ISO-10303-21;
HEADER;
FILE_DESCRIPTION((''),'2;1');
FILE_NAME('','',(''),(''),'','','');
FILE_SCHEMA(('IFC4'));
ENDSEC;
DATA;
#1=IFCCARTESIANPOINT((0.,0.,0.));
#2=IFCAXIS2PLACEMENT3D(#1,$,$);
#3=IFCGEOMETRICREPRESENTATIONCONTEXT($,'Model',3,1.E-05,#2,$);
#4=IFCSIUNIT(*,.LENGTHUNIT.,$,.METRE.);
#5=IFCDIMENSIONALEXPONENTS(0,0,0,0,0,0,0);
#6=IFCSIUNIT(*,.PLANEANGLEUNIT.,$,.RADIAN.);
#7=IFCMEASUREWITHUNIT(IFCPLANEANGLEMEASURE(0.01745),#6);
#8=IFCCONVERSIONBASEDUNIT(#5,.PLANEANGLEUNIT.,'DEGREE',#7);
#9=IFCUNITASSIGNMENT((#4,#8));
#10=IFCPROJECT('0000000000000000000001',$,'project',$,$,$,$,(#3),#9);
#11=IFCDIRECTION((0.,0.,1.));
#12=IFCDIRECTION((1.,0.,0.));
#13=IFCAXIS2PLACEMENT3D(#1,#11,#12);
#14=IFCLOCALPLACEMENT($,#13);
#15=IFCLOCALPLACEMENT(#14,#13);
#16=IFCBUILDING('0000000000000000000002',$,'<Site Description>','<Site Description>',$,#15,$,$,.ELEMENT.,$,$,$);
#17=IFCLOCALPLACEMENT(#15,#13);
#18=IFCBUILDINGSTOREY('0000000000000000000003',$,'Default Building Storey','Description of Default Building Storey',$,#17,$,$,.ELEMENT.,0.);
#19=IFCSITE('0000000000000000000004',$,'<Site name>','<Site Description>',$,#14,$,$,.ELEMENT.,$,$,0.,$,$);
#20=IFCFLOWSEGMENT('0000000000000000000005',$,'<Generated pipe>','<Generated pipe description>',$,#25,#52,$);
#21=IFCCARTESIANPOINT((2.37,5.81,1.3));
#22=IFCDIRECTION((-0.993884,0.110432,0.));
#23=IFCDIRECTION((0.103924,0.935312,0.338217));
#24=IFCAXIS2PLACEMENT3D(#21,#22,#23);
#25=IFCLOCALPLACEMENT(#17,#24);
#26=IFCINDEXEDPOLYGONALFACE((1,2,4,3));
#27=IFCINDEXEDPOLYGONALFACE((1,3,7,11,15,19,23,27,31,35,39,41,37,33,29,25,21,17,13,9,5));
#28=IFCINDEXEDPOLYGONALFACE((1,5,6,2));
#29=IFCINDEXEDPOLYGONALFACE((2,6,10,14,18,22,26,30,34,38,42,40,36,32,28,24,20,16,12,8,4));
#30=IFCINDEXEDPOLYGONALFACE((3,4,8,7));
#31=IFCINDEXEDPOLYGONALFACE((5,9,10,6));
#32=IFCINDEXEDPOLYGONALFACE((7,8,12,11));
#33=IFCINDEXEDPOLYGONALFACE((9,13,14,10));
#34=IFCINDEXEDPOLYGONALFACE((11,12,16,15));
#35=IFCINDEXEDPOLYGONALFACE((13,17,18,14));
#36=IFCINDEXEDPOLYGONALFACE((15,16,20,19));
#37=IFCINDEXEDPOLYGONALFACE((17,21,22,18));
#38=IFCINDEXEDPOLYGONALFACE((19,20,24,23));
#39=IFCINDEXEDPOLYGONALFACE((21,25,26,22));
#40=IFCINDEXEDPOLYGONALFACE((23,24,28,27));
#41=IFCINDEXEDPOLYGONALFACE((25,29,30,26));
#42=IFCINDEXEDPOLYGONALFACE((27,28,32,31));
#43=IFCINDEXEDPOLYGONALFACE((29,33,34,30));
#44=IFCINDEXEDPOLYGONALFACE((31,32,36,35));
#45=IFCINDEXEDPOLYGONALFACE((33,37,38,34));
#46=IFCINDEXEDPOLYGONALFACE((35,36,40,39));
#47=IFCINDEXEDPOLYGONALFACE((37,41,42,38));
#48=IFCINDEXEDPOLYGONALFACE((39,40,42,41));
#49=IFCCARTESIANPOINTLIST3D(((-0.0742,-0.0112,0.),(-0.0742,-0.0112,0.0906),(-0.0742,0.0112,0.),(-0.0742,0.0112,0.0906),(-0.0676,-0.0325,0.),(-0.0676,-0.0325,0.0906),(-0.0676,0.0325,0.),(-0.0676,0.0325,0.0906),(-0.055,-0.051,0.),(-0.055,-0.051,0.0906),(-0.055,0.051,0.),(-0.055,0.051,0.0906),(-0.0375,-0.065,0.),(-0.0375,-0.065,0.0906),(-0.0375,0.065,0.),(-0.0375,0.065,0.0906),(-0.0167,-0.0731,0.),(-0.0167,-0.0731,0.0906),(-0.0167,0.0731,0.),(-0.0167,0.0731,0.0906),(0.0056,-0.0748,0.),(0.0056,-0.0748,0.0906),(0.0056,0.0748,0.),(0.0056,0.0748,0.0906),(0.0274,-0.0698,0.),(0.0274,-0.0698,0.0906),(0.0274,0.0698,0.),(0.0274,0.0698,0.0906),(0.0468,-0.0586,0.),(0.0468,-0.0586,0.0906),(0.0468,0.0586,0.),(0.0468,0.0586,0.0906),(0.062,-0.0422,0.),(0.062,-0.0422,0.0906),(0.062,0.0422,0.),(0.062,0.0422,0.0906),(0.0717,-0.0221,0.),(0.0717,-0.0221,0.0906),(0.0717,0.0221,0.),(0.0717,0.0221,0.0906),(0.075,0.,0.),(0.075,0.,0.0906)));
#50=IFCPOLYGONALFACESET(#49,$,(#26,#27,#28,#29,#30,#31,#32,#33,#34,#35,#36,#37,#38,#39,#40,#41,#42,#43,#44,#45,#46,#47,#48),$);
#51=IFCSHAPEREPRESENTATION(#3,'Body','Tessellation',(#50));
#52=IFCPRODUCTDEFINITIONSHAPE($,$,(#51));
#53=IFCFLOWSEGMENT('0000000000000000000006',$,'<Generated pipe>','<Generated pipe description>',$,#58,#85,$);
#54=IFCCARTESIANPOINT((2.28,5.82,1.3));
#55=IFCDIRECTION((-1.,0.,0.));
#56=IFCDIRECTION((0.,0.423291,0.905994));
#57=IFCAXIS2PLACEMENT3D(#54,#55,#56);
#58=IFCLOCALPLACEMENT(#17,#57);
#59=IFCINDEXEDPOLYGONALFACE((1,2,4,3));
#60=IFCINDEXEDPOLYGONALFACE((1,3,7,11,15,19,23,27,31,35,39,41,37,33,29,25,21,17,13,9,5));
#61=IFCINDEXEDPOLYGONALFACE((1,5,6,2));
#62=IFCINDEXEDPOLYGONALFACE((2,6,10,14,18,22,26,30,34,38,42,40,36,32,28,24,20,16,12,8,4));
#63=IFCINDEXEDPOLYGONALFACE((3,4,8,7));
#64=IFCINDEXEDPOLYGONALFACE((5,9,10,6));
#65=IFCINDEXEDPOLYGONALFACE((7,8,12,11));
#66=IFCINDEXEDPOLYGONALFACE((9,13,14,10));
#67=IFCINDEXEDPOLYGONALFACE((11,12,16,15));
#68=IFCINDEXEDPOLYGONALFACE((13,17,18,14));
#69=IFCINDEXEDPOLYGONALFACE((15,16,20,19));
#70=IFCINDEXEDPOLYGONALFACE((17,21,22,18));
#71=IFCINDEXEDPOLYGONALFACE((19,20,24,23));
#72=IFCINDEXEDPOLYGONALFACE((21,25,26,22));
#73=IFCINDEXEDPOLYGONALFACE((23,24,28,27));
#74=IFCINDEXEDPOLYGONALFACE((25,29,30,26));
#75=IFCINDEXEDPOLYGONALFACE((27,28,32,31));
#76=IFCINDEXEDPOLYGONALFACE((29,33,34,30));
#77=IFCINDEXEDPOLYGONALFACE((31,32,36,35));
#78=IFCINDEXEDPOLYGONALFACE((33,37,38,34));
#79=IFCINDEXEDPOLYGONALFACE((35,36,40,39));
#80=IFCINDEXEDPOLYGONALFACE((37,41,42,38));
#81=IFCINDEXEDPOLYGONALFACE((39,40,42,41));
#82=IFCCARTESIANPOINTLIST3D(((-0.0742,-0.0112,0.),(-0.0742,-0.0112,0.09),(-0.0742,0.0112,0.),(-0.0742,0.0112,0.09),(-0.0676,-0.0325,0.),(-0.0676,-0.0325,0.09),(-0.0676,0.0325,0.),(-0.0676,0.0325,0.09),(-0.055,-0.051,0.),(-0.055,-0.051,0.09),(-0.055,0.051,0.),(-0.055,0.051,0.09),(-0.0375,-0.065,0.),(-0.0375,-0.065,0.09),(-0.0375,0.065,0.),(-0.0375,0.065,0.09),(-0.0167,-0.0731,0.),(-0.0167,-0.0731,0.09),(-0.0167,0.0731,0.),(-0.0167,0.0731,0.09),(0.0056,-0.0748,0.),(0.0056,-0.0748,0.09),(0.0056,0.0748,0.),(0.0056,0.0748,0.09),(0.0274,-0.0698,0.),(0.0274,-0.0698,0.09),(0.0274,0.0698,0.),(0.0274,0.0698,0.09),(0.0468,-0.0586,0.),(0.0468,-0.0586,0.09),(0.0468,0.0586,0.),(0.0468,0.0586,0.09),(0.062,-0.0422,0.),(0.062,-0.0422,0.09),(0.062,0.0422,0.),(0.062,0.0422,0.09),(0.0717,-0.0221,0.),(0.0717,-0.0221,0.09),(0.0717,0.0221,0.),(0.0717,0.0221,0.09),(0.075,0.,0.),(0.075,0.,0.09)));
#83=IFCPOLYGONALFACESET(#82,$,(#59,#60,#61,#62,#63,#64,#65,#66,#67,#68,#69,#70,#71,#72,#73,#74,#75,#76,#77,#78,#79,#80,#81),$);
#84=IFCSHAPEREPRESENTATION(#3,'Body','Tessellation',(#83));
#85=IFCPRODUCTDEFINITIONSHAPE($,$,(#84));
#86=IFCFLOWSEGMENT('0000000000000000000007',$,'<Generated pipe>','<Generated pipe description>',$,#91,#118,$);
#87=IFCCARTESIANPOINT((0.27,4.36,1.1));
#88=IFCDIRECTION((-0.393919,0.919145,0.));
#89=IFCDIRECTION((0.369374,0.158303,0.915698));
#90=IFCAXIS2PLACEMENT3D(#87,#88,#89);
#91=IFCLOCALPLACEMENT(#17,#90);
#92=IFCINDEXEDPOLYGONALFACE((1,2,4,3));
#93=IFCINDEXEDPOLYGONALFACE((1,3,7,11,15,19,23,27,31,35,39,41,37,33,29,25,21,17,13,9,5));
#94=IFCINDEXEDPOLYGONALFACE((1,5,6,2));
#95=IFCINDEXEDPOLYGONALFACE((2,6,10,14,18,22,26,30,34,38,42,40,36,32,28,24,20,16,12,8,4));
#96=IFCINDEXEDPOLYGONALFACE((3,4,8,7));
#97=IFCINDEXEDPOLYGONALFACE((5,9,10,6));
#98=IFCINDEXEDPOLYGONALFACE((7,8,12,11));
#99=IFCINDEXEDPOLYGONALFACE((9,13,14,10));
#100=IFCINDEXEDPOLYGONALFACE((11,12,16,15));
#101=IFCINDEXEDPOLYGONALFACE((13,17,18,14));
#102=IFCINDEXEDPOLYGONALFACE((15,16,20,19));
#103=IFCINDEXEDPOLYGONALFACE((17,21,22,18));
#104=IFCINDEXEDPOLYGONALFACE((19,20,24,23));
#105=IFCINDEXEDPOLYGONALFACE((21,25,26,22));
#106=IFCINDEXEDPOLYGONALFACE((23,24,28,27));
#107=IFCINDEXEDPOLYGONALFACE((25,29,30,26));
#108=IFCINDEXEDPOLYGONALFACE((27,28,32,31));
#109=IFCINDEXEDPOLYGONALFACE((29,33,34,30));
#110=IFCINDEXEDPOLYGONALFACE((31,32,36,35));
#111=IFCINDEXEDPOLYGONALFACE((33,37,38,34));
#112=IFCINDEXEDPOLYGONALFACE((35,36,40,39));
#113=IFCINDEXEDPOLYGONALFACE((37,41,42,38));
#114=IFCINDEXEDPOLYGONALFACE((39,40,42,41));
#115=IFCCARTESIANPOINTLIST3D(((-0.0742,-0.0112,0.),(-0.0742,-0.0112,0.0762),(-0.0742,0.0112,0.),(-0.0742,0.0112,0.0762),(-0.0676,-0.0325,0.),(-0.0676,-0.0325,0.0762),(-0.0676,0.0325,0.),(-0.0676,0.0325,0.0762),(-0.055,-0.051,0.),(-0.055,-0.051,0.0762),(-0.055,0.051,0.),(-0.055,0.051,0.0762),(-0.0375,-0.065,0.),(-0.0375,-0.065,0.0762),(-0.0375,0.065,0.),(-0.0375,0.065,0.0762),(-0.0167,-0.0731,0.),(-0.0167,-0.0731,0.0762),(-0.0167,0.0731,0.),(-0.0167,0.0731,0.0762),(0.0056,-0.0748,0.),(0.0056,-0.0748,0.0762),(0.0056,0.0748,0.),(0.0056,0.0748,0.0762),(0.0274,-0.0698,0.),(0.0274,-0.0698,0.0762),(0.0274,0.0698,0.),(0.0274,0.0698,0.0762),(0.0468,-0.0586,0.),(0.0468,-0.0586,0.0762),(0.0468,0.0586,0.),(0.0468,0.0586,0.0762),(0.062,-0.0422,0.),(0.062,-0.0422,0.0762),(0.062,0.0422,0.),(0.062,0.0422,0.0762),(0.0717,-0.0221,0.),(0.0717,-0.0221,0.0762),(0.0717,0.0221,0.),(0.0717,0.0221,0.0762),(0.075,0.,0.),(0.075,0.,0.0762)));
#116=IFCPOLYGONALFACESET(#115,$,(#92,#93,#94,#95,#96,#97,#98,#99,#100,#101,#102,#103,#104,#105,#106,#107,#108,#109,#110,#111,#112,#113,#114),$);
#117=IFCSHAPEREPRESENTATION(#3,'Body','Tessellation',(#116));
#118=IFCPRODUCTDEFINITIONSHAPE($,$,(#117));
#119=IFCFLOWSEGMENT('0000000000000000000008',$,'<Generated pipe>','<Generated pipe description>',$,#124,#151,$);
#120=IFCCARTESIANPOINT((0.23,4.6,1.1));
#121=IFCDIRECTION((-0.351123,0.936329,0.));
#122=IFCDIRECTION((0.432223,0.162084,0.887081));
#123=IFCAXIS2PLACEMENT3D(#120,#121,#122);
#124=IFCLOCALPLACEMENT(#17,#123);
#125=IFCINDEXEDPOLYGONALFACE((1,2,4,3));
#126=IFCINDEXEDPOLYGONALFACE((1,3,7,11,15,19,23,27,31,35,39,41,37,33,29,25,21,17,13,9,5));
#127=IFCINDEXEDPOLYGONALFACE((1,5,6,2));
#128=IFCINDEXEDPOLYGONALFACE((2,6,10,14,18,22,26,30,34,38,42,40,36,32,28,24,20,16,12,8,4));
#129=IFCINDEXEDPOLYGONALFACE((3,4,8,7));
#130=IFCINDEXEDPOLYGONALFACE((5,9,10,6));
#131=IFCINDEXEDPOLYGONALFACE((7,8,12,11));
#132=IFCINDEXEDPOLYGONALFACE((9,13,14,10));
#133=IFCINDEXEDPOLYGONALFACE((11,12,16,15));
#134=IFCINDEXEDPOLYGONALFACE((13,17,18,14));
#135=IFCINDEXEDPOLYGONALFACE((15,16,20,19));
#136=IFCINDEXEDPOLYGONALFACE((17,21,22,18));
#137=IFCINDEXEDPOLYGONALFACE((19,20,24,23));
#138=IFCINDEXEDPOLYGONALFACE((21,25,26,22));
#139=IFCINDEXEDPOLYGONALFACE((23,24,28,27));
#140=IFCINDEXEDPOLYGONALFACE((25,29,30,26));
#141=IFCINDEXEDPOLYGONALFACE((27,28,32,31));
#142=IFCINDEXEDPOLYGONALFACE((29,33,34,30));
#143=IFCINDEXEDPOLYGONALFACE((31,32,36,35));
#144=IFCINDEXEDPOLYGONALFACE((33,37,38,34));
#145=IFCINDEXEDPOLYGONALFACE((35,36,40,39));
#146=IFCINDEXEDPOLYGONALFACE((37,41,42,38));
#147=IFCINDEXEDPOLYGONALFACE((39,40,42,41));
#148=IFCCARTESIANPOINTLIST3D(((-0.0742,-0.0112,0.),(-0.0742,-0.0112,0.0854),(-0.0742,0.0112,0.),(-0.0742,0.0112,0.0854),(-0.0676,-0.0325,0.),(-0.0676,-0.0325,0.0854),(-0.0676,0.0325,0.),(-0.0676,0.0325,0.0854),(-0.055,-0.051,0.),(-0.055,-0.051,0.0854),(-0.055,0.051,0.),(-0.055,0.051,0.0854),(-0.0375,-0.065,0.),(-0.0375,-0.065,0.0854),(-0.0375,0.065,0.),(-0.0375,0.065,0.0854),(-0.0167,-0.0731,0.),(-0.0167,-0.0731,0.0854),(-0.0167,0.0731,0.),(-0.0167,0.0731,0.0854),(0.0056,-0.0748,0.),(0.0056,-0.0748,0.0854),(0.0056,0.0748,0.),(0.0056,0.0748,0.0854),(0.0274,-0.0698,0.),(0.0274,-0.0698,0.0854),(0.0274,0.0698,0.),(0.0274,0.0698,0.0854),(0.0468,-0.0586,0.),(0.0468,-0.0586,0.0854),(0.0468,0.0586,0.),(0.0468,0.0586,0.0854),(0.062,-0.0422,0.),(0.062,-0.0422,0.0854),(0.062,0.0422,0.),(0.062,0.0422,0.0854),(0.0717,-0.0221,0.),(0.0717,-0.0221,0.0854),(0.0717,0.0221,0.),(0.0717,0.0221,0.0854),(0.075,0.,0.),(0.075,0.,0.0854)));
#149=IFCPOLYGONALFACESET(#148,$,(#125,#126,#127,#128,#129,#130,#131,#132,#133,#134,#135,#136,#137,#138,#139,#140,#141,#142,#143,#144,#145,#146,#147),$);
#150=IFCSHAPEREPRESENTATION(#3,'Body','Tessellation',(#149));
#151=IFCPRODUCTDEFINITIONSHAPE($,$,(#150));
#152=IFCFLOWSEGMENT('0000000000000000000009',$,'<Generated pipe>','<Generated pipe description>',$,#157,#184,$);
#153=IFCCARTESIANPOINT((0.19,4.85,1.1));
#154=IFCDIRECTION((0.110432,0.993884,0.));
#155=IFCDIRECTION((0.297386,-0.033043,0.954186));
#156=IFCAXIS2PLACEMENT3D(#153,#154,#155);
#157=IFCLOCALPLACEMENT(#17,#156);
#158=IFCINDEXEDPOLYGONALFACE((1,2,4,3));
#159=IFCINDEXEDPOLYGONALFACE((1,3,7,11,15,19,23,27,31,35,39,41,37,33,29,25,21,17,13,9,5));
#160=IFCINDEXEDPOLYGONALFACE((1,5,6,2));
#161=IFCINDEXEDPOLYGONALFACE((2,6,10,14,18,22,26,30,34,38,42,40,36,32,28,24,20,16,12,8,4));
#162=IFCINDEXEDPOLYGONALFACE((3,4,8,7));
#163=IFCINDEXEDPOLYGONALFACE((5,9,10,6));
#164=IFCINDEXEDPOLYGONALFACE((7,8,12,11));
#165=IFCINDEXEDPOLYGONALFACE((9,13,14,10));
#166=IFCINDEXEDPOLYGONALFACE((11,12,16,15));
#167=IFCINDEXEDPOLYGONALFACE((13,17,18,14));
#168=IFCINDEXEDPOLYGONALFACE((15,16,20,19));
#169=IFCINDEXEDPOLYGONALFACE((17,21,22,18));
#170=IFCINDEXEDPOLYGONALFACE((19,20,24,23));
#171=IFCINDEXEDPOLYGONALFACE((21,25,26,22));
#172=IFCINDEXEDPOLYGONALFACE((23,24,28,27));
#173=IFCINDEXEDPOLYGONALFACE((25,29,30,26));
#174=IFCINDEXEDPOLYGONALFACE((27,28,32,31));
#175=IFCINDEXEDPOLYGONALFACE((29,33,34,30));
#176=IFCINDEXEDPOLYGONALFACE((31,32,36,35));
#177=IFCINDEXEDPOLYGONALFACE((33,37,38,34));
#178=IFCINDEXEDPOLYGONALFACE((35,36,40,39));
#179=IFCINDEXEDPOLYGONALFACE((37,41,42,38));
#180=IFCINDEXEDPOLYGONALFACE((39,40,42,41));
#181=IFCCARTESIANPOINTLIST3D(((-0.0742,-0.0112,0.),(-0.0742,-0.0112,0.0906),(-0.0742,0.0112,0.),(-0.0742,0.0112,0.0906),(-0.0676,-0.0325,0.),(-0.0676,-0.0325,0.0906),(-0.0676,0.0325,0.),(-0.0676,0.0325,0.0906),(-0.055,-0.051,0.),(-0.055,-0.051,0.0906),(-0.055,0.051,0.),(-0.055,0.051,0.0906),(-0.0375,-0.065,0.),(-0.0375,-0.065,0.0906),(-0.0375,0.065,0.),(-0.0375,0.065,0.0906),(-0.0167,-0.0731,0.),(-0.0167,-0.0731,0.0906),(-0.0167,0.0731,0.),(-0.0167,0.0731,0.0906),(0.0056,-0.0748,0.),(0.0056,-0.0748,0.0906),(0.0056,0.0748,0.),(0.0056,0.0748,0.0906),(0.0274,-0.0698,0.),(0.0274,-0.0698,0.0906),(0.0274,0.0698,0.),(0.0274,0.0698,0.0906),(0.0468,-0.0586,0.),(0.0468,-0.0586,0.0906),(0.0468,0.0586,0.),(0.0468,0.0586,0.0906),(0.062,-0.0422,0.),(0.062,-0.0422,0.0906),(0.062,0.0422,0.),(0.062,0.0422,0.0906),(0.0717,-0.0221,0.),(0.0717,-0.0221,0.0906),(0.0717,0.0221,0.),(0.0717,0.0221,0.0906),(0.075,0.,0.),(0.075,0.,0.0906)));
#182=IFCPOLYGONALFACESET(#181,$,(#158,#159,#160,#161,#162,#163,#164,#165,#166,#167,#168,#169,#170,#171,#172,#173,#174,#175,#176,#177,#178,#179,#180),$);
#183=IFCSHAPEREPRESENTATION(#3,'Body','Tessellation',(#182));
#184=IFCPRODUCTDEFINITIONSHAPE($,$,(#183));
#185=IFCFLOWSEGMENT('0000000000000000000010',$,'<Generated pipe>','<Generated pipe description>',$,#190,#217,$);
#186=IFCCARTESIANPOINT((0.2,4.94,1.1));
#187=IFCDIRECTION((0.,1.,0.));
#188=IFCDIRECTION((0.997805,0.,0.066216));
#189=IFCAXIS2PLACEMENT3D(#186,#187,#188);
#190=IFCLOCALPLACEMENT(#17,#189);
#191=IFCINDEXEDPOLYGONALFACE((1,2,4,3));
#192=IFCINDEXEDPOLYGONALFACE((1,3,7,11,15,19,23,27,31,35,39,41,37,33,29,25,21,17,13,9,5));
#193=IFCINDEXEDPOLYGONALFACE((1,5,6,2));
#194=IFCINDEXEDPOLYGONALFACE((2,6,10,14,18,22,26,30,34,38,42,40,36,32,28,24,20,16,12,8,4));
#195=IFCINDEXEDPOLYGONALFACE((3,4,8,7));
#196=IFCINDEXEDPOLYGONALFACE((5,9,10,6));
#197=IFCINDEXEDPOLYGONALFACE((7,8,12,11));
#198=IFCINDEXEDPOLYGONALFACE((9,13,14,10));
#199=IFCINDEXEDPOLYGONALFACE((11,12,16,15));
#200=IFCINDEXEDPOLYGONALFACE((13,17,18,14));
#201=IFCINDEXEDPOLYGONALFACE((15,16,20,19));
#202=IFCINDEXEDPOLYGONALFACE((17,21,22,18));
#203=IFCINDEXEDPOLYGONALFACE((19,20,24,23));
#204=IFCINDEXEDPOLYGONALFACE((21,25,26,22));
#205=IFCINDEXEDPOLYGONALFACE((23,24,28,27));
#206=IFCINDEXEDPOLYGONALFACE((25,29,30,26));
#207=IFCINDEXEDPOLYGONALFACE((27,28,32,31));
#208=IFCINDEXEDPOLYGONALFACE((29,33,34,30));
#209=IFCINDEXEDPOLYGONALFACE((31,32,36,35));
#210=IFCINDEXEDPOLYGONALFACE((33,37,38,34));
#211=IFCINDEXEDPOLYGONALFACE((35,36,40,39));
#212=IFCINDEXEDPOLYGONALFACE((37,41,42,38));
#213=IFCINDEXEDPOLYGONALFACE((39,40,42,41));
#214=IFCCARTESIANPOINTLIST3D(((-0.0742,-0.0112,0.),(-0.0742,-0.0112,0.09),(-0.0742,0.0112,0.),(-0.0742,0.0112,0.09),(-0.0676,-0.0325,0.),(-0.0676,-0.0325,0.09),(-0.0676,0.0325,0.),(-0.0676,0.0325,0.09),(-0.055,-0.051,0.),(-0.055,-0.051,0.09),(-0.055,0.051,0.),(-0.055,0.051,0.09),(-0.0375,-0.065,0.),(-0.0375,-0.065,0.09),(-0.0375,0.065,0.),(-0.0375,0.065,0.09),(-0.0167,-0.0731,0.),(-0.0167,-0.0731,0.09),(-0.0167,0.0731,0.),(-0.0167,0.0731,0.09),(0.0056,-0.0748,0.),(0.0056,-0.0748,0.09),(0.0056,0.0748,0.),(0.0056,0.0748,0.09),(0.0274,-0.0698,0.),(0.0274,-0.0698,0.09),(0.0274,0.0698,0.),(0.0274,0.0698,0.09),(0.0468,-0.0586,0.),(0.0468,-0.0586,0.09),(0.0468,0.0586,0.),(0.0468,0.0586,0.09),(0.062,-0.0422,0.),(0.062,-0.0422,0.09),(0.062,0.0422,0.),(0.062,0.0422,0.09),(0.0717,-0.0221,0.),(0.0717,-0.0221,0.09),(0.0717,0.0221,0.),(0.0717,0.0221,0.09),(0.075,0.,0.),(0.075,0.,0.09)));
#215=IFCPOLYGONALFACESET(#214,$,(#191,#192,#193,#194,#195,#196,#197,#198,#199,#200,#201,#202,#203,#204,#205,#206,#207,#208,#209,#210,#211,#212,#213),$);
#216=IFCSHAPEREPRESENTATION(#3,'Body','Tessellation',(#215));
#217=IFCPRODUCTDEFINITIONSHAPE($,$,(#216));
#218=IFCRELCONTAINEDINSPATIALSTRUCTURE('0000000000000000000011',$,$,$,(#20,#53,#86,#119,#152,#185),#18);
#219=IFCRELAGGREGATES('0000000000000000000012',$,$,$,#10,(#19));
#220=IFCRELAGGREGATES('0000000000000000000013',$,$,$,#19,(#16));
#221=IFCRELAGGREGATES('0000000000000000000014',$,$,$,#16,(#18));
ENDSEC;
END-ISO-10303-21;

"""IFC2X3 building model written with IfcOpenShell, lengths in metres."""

from ifc_helpers import new_model, entity, si_unit, converted_unit, frame, origin, origin_with_axes, origin_2d_with_axis, place, context, project, spatial, circle, extrude, element, save


model = new_model("IFC2X3")

# Units and contexts
model_context = context("Model", 3, precision=1e-05, world=origin())
ifc_project = project(units=[si_unit("LENGTHUNIT", "METRE"), converted_unit("PLANEANGLEUNIT", "DEGREE", entity("IfcPlaneAngleMeasure", 0.01745), si_unit("PLANEANGLEUNIT", "RADIAN"), dimensions=[0, 0, 0, 0, 0, 0, 0])], contexts=[model_context])

# Site, building, storey
site_placement = place(None, origin_with_axes())
site = spatial("IfcSite", under=ifc_project, at=site_placement, Name="<Site name>", Description="<Site Description>", CompositionType="ELEMENT", RefElevation=0.0)
building_placement = place(site_placement, origin_with_axes())
building = spatial("IfcBuilding", under=site, at=building_placement, Name="<Site Description>", Description="<Site Description>", CompositionType="ELEMENT")
storey_placement = place(building_placement, origin_with_axes())
storey = spatial("IfcBuildingStorey", under=building, at=storey_placement, Name="Default Building Storey", Description="Description of Default Building Storey", CompositionType="ELEMENT", Elevation=0.0)

# Flow segments
flow_segment_1_placement = place(storey_placement, frame((2.37, 5.81, 1.3), z_axis=(-0.993884, 0.110432, 0.0), x_axis=(0.103924, 0.935312, 0.338217)))
element("IfcFlowSegment", 1, at=flow_segment_1_placement, inside=storey, Name="<Generated pipe>", Description="<Generated pipe description>", context=model_context, shape_type="SweptSolid", body=[
    extrude(circle(Radius=0.075, at=origin_2d_with_axis()), origin_with_axes(), (0.0, 0.0, 1.0), 0.0906),
])
flow_segment_2_placement = place(storey_placement, frame((2.28, 5.82, 1.3), z_axis=(-1.0, 0.0, 0.0), x_axis=(0.0, 0.423291, 0.905994)))
element("IfcFlowSegment", 2, at=flow_segment_2_placement, inside=storey, Name="<Generated pipe>", Description="<Generated pipe description>", context=model_context, shape_type="SweptSolid", body=[
    extrude(circle(Radius=0.075, at=origin_2d_with_axis()), origin_with_axes(), (0.0, 0.0, 1.0), 0.09),
])
flow_segment_3_placement = place(storey_placement, frame((0.27, 4.36, 1.1), z_axis=(-0.393919, 0.919145, 0.0), x_axis=(0.369374, 0.158303, 0.915698)))
element("IfcFlowSegment", 3, at=flow_segment_3_placement, inside=storey, Name="<Generated pipe>", Description="<Generated pipe description>", context=model_context, shape_type="SweptSolid", body=[
    extrude(circle(Radius=0.075, at=origin_2d_with_axis()), origin_with_axes(), (0.0, 0.0, 1.0), 0.0762),
])
flow_segment_4_placement = place(storey_placement, frame((0.23, 4.6, 1.1), z_axis=(-0.351123, 0.936329, 0.0), x_axis=(0.432223, 0.162084, 0.887081)))
element("IfcFlowSegment", 4, at=flow_segment_4_placement, inside=storey, Name="<Generated pipe>", Description="<Generated pipe description>", context=model_context, shape_type="SweptSolid", body=[
    extrude(circle(Radius=0.075, at=origin_2d_with_axis()), origin_with_axes(), (0.0, 0.0, 1.0), 0.0854),
])
flow_segment_5_placement = place(storey_placement, frame((0.19, 4.85, 1.1), z_axis=(0.110432, 0.993884, 0.0), x_axis=(0.297386, -0.033043, 0.954186)))
element("IfcFlowSegment", 5, at=flow_segment_5_placement, inside=storey, Name="<Generated pipe>", Description="<Generated pipe description>", context=model_context, shape_type="SweptSolid", body=[
    extrude(circle(Radius=0.075, at=origin_2d_with_axis()), origin_with_axes(), (0.0, 0.0, 1.0), 0.0906),
])
flow_segment_6_placement = place(storey_placement, frame((0.2, 4.94, 1.1), z_axis=(0.0, 1.0, 0.0), x_axis=(0.997805, 0.0, 0.066216)))
element("IfcFlowSegment", 6, at=flow_segment_6_placement, inside=storey, Name="<Generated pipe>", Description="<Generated pipe description>", context=model_context, shape_type="SweptSolid", body=[
    extrude(circle(Radius=0.075, at=origin_2d_with_axis()), origin_with_axes(), (0.0, 0.0, 1.0), 0.09),
])

save(model, "model.ifc")
